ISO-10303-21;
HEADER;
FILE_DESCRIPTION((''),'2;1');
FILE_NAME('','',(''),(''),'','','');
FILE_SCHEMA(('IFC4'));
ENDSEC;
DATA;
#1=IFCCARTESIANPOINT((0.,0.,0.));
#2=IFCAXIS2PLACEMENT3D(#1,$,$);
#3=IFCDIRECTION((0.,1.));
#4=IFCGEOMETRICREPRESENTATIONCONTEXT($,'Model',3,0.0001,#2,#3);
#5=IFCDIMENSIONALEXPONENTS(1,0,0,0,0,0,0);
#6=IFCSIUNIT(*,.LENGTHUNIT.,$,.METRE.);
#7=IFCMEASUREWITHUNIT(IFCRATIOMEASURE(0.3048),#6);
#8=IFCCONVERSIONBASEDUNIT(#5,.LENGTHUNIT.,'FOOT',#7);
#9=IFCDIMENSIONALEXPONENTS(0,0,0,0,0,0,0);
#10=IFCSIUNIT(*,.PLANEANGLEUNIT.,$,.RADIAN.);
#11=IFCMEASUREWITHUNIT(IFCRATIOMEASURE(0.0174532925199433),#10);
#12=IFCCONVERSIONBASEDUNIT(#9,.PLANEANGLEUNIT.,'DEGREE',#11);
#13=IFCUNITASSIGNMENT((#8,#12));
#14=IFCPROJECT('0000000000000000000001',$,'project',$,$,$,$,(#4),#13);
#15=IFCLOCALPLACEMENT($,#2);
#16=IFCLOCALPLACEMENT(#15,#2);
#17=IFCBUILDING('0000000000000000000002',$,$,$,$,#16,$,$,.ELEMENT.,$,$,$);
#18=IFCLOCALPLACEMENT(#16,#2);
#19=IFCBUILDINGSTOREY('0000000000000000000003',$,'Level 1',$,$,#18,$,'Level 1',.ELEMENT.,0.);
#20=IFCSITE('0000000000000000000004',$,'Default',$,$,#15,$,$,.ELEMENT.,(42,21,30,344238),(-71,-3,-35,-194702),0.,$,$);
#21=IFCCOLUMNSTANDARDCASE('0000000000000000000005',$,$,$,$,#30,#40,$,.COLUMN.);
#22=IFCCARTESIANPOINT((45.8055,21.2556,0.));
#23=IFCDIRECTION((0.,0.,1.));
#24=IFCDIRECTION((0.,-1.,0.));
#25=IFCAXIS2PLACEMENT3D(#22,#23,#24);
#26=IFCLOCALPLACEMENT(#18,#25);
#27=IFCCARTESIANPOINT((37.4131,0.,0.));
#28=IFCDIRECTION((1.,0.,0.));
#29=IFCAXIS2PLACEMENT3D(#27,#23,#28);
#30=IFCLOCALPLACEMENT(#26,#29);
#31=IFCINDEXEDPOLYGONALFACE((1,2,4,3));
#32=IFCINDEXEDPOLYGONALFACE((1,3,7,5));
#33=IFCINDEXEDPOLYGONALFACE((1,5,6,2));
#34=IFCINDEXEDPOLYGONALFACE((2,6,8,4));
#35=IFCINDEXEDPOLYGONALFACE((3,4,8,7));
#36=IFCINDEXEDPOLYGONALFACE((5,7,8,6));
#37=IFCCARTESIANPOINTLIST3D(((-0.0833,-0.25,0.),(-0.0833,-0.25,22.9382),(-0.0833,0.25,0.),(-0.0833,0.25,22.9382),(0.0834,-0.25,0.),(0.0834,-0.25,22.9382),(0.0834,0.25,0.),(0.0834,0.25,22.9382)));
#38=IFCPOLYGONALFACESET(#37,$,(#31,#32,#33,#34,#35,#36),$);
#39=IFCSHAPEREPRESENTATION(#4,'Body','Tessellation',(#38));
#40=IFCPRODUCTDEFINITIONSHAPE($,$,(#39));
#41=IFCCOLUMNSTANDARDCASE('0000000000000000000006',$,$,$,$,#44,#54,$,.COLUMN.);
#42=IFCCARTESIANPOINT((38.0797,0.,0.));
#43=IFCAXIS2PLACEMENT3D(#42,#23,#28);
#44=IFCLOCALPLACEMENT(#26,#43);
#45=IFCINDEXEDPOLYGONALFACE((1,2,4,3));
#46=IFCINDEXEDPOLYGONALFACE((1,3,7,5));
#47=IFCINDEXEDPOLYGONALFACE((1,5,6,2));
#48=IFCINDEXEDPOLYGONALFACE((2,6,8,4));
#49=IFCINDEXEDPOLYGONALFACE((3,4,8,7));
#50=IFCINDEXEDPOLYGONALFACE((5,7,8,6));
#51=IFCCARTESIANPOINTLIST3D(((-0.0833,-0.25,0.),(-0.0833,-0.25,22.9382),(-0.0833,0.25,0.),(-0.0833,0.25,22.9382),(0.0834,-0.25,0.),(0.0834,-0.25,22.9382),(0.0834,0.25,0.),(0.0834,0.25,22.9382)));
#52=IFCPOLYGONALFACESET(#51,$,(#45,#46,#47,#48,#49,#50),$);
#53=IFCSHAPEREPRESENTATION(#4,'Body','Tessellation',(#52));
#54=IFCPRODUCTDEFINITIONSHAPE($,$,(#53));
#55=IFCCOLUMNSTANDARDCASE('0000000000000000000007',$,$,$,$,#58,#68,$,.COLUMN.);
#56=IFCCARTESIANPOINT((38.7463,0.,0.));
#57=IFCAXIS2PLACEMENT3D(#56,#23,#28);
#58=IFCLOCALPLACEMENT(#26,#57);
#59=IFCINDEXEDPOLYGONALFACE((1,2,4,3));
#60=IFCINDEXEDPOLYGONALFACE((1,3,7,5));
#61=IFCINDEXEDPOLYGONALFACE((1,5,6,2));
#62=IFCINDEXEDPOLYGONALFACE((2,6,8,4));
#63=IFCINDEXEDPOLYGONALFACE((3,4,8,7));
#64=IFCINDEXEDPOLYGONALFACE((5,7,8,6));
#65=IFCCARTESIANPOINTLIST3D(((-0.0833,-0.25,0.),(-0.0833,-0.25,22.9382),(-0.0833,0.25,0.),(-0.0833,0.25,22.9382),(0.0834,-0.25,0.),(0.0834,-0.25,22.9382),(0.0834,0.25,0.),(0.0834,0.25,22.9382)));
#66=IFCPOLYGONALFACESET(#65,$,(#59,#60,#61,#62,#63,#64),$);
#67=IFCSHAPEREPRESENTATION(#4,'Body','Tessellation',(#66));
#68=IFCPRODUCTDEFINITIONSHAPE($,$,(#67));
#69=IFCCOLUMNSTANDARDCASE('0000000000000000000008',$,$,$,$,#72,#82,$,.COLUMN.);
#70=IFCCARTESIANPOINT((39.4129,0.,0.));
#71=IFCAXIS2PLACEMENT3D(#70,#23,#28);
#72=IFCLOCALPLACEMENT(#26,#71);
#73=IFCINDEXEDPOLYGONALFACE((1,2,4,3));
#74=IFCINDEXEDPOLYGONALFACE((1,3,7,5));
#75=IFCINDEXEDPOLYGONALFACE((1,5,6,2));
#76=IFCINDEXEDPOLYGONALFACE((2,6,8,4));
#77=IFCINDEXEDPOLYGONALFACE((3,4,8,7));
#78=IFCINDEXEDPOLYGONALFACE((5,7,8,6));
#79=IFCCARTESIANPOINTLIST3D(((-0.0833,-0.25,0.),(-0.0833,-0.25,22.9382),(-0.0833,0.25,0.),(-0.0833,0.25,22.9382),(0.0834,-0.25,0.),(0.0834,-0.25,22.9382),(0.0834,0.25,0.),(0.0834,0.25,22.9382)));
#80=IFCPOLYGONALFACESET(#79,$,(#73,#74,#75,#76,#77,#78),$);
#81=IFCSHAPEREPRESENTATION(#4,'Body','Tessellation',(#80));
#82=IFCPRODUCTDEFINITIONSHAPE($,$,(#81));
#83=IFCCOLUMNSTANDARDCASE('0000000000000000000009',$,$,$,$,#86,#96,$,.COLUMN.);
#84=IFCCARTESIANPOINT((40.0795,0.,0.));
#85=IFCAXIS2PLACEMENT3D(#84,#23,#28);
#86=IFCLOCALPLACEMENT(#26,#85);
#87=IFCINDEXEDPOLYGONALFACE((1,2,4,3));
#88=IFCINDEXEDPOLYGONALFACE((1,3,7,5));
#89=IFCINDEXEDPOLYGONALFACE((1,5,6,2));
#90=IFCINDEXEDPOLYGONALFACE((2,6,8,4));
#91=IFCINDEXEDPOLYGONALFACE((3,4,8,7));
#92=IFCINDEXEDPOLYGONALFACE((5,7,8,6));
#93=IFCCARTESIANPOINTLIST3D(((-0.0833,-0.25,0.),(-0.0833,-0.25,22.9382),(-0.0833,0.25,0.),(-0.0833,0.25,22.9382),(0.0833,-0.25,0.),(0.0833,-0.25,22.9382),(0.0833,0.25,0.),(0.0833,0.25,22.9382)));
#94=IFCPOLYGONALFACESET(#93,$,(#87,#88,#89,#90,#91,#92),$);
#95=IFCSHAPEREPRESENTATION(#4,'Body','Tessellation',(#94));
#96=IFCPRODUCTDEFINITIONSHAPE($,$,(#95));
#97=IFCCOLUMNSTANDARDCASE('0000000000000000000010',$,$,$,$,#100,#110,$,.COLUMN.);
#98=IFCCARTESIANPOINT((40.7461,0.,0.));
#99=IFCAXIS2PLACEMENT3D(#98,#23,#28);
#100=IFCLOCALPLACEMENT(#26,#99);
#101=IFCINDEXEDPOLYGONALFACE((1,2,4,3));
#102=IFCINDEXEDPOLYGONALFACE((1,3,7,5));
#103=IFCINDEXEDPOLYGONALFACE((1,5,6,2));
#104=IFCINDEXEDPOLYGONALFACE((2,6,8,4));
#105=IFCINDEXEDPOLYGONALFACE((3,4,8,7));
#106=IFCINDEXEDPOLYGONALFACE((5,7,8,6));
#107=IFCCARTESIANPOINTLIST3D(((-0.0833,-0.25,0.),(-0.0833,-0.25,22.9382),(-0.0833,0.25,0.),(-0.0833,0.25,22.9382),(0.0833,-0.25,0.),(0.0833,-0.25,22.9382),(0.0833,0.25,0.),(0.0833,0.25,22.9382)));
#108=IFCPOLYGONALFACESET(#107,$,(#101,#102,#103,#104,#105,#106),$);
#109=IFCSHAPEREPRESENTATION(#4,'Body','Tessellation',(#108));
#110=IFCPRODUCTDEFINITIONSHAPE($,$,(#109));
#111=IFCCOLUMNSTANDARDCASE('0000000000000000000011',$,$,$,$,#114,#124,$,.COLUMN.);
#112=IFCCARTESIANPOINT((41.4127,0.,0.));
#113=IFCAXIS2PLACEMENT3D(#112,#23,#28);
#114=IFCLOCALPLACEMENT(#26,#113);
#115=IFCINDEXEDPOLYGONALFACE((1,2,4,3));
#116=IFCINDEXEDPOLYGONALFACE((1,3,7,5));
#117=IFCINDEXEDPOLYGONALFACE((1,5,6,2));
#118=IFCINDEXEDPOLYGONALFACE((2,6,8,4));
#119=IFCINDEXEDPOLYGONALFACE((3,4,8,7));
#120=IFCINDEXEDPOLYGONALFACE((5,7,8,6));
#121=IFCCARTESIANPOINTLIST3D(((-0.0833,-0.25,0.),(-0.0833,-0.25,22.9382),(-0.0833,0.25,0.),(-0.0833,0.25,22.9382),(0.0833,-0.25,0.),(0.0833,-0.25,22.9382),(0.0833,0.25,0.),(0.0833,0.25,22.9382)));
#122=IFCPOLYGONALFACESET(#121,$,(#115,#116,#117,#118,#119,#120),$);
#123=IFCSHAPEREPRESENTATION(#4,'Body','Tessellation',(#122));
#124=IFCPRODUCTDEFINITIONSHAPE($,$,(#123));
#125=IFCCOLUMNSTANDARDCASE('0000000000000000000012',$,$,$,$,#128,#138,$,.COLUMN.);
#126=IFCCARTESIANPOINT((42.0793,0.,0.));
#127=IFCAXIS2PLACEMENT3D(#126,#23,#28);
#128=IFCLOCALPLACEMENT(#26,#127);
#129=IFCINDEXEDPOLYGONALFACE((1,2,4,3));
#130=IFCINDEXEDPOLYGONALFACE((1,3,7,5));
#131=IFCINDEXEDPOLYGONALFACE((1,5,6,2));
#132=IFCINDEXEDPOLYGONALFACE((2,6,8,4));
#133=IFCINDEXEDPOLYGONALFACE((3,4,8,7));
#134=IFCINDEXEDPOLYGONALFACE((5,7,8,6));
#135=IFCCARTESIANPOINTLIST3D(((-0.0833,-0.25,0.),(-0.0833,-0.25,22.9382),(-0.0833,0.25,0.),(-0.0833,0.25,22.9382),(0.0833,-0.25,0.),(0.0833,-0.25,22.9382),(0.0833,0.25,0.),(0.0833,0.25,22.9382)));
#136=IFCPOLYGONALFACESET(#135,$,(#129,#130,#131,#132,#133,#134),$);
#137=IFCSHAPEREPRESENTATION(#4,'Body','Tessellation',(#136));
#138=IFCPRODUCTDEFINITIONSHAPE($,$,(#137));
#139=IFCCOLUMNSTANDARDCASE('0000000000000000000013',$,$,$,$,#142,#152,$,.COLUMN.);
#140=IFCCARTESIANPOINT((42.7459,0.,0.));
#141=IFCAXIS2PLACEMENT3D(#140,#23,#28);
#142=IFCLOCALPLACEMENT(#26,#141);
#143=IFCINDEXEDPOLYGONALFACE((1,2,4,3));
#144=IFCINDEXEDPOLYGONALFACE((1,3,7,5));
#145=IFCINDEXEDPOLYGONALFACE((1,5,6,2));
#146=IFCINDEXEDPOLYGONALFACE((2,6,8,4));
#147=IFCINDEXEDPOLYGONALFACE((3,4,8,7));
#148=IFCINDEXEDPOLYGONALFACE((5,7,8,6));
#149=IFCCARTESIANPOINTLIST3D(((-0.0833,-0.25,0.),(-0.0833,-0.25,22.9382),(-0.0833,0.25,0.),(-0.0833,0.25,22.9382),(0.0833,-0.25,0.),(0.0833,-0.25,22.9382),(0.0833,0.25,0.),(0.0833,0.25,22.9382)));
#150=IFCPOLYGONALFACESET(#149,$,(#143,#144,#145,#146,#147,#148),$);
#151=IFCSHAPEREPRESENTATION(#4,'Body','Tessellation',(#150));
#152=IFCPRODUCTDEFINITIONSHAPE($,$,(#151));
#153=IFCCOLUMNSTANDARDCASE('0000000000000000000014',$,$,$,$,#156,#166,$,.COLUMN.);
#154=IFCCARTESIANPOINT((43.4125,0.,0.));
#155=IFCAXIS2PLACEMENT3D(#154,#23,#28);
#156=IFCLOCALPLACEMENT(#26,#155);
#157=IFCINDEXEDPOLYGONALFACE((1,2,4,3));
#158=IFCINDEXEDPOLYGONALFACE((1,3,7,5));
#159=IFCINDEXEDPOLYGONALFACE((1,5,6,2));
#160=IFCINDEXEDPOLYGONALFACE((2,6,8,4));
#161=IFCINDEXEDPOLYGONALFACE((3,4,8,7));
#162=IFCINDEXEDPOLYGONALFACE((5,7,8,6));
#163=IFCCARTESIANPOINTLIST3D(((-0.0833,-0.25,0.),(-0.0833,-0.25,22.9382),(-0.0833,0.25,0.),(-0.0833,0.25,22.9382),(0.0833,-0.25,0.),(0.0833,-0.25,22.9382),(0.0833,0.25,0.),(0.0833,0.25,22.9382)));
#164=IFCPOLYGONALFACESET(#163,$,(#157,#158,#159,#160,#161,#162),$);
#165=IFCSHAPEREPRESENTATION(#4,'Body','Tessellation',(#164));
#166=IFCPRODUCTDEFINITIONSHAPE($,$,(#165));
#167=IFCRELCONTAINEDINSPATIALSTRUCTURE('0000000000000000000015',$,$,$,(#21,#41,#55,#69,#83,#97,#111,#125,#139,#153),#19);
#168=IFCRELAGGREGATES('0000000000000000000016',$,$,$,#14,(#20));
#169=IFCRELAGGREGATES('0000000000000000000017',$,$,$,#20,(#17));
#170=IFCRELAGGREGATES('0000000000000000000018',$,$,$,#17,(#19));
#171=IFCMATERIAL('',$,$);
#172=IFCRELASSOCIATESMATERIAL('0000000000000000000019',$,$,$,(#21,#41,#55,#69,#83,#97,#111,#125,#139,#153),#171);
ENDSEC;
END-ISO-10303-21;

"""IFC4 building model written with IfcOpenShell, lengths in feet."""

from ifc_helpers import new_model, entity, si_unit, converted_unit, direction, frame, origin, place, context, project, spatial, rectangle, extrude, material, element, save


model = new_model("IFC4")

# Units and contexts
model_context = context("Model", 3, precision=0.0001, world=origin(), true_north=direction((0.0, 1.0)))
ifc_project = project(units=[converted_unit("LENGTHUNIT", "FOOT", entity("IfcRatioMeasure", 0.3048), si_unit("LENGTHUNIT", "METRE"), dimensions=[1, 0, 0, 0, 0, 0, 0]), converted_unit("PLANEANGLEUNIT", "DEGREE", entity("IfcRatioMeasure", 0.0174532925199433), si_unit("PLANEANGLEUNIT", "RADIAN"), dimensions=[0, 0, 0, 0, 0, 0, 0])], contexts=[model_context])

# Site, building, storey
site_placement = place(None, origin())
site = spatial("IfcSite", under=ifc_project, at=site_placement, Name="Default", CompositionType="ELEMENT", RefLatitude=(42, 21, 30, 344238), RefLongitude=(-71, -3, -35, -194702), RefElevation=0.0)
building_placement = place(site_placement, origin())
building = spatial("IfcBuilding", under=site, at=building_placement, CompositionType="ELEMENT")
storey_placement = place(building_placement, origin())
storey = spatial("IfcBuildingStorey", under=building, at=storey_placement, Name="Level 1", LongName="Level 1", CompositionType="ELEMENT", Elevation=0.0)

# Columns
ifc_material = material(Name="")
placement = place(storey_placement, frame((45.8055, 21.2556, 0.0), z_axis=(0.0, 0.0, 1.0), x_axis=(0.0, -1.0, 0.0)))
for number, where, z_axis, x_axis in (
    (1, (37.4131, 0.0, 0.0), (0.0, 0.0, 1.0), (1.0, 0.0, 0.0)),
    (2, (38.0797, 0.0, 0.0), (0.0, 0.0, 1.0), (1.0, 0.0, 0.0)),
    (3, (38.7463, 0.0, 0.0), (0.0, 0.0, 1.0), (1.0, 0.0, 0.0)),
    (4, (39.4129, 0.0, 0.0), (0.0, 0.0, 1.0), (1.0, 0.0, 0.0)),
    (5, (40.0795, 0.0, 0.0), (0.0, 0.0, 1.0), (1.0, 0.0, 0.0)),
    (6, (40.7461, 0.0, 0.0), (0.0, 0.0, 1.0), (1.0, 0.0, 0.0)),
    (7, (41.4127, 0.0, 0.0), (0.0, 0.0, 1.0), (1.0, 0.0, 0.0)),
    (8, (42.0793, 0.0, 0.0), (0.0, 0.0, 1.0), (1.0, 0.0, 0.0)),
    (9, (42.7459, 0.0, 0.0), (0.0, 0.0, 1.0), (1.0, 0.0, 0.0)),
    (10, (43.4125, 0.0, 0.0), (0.0, 0.0, 1.0), (1.0, 0.0, 0.0)),
):
    element("IfcColumnStandardCase", number, at=place(placement, frame(where, z_axis=z_axis, x_axis=x_axis)), inside=storey, material=ifc_material, PredefinedType="COLUMN", context=model_context, shape_type="SweptSolid", body=[
        extrude(rectangle(XDim=0.1667, YDim=0.5), origin(), (0.0, 0.0, 1.0), 22.9382),
    ])

save(model, "model.ifc")
